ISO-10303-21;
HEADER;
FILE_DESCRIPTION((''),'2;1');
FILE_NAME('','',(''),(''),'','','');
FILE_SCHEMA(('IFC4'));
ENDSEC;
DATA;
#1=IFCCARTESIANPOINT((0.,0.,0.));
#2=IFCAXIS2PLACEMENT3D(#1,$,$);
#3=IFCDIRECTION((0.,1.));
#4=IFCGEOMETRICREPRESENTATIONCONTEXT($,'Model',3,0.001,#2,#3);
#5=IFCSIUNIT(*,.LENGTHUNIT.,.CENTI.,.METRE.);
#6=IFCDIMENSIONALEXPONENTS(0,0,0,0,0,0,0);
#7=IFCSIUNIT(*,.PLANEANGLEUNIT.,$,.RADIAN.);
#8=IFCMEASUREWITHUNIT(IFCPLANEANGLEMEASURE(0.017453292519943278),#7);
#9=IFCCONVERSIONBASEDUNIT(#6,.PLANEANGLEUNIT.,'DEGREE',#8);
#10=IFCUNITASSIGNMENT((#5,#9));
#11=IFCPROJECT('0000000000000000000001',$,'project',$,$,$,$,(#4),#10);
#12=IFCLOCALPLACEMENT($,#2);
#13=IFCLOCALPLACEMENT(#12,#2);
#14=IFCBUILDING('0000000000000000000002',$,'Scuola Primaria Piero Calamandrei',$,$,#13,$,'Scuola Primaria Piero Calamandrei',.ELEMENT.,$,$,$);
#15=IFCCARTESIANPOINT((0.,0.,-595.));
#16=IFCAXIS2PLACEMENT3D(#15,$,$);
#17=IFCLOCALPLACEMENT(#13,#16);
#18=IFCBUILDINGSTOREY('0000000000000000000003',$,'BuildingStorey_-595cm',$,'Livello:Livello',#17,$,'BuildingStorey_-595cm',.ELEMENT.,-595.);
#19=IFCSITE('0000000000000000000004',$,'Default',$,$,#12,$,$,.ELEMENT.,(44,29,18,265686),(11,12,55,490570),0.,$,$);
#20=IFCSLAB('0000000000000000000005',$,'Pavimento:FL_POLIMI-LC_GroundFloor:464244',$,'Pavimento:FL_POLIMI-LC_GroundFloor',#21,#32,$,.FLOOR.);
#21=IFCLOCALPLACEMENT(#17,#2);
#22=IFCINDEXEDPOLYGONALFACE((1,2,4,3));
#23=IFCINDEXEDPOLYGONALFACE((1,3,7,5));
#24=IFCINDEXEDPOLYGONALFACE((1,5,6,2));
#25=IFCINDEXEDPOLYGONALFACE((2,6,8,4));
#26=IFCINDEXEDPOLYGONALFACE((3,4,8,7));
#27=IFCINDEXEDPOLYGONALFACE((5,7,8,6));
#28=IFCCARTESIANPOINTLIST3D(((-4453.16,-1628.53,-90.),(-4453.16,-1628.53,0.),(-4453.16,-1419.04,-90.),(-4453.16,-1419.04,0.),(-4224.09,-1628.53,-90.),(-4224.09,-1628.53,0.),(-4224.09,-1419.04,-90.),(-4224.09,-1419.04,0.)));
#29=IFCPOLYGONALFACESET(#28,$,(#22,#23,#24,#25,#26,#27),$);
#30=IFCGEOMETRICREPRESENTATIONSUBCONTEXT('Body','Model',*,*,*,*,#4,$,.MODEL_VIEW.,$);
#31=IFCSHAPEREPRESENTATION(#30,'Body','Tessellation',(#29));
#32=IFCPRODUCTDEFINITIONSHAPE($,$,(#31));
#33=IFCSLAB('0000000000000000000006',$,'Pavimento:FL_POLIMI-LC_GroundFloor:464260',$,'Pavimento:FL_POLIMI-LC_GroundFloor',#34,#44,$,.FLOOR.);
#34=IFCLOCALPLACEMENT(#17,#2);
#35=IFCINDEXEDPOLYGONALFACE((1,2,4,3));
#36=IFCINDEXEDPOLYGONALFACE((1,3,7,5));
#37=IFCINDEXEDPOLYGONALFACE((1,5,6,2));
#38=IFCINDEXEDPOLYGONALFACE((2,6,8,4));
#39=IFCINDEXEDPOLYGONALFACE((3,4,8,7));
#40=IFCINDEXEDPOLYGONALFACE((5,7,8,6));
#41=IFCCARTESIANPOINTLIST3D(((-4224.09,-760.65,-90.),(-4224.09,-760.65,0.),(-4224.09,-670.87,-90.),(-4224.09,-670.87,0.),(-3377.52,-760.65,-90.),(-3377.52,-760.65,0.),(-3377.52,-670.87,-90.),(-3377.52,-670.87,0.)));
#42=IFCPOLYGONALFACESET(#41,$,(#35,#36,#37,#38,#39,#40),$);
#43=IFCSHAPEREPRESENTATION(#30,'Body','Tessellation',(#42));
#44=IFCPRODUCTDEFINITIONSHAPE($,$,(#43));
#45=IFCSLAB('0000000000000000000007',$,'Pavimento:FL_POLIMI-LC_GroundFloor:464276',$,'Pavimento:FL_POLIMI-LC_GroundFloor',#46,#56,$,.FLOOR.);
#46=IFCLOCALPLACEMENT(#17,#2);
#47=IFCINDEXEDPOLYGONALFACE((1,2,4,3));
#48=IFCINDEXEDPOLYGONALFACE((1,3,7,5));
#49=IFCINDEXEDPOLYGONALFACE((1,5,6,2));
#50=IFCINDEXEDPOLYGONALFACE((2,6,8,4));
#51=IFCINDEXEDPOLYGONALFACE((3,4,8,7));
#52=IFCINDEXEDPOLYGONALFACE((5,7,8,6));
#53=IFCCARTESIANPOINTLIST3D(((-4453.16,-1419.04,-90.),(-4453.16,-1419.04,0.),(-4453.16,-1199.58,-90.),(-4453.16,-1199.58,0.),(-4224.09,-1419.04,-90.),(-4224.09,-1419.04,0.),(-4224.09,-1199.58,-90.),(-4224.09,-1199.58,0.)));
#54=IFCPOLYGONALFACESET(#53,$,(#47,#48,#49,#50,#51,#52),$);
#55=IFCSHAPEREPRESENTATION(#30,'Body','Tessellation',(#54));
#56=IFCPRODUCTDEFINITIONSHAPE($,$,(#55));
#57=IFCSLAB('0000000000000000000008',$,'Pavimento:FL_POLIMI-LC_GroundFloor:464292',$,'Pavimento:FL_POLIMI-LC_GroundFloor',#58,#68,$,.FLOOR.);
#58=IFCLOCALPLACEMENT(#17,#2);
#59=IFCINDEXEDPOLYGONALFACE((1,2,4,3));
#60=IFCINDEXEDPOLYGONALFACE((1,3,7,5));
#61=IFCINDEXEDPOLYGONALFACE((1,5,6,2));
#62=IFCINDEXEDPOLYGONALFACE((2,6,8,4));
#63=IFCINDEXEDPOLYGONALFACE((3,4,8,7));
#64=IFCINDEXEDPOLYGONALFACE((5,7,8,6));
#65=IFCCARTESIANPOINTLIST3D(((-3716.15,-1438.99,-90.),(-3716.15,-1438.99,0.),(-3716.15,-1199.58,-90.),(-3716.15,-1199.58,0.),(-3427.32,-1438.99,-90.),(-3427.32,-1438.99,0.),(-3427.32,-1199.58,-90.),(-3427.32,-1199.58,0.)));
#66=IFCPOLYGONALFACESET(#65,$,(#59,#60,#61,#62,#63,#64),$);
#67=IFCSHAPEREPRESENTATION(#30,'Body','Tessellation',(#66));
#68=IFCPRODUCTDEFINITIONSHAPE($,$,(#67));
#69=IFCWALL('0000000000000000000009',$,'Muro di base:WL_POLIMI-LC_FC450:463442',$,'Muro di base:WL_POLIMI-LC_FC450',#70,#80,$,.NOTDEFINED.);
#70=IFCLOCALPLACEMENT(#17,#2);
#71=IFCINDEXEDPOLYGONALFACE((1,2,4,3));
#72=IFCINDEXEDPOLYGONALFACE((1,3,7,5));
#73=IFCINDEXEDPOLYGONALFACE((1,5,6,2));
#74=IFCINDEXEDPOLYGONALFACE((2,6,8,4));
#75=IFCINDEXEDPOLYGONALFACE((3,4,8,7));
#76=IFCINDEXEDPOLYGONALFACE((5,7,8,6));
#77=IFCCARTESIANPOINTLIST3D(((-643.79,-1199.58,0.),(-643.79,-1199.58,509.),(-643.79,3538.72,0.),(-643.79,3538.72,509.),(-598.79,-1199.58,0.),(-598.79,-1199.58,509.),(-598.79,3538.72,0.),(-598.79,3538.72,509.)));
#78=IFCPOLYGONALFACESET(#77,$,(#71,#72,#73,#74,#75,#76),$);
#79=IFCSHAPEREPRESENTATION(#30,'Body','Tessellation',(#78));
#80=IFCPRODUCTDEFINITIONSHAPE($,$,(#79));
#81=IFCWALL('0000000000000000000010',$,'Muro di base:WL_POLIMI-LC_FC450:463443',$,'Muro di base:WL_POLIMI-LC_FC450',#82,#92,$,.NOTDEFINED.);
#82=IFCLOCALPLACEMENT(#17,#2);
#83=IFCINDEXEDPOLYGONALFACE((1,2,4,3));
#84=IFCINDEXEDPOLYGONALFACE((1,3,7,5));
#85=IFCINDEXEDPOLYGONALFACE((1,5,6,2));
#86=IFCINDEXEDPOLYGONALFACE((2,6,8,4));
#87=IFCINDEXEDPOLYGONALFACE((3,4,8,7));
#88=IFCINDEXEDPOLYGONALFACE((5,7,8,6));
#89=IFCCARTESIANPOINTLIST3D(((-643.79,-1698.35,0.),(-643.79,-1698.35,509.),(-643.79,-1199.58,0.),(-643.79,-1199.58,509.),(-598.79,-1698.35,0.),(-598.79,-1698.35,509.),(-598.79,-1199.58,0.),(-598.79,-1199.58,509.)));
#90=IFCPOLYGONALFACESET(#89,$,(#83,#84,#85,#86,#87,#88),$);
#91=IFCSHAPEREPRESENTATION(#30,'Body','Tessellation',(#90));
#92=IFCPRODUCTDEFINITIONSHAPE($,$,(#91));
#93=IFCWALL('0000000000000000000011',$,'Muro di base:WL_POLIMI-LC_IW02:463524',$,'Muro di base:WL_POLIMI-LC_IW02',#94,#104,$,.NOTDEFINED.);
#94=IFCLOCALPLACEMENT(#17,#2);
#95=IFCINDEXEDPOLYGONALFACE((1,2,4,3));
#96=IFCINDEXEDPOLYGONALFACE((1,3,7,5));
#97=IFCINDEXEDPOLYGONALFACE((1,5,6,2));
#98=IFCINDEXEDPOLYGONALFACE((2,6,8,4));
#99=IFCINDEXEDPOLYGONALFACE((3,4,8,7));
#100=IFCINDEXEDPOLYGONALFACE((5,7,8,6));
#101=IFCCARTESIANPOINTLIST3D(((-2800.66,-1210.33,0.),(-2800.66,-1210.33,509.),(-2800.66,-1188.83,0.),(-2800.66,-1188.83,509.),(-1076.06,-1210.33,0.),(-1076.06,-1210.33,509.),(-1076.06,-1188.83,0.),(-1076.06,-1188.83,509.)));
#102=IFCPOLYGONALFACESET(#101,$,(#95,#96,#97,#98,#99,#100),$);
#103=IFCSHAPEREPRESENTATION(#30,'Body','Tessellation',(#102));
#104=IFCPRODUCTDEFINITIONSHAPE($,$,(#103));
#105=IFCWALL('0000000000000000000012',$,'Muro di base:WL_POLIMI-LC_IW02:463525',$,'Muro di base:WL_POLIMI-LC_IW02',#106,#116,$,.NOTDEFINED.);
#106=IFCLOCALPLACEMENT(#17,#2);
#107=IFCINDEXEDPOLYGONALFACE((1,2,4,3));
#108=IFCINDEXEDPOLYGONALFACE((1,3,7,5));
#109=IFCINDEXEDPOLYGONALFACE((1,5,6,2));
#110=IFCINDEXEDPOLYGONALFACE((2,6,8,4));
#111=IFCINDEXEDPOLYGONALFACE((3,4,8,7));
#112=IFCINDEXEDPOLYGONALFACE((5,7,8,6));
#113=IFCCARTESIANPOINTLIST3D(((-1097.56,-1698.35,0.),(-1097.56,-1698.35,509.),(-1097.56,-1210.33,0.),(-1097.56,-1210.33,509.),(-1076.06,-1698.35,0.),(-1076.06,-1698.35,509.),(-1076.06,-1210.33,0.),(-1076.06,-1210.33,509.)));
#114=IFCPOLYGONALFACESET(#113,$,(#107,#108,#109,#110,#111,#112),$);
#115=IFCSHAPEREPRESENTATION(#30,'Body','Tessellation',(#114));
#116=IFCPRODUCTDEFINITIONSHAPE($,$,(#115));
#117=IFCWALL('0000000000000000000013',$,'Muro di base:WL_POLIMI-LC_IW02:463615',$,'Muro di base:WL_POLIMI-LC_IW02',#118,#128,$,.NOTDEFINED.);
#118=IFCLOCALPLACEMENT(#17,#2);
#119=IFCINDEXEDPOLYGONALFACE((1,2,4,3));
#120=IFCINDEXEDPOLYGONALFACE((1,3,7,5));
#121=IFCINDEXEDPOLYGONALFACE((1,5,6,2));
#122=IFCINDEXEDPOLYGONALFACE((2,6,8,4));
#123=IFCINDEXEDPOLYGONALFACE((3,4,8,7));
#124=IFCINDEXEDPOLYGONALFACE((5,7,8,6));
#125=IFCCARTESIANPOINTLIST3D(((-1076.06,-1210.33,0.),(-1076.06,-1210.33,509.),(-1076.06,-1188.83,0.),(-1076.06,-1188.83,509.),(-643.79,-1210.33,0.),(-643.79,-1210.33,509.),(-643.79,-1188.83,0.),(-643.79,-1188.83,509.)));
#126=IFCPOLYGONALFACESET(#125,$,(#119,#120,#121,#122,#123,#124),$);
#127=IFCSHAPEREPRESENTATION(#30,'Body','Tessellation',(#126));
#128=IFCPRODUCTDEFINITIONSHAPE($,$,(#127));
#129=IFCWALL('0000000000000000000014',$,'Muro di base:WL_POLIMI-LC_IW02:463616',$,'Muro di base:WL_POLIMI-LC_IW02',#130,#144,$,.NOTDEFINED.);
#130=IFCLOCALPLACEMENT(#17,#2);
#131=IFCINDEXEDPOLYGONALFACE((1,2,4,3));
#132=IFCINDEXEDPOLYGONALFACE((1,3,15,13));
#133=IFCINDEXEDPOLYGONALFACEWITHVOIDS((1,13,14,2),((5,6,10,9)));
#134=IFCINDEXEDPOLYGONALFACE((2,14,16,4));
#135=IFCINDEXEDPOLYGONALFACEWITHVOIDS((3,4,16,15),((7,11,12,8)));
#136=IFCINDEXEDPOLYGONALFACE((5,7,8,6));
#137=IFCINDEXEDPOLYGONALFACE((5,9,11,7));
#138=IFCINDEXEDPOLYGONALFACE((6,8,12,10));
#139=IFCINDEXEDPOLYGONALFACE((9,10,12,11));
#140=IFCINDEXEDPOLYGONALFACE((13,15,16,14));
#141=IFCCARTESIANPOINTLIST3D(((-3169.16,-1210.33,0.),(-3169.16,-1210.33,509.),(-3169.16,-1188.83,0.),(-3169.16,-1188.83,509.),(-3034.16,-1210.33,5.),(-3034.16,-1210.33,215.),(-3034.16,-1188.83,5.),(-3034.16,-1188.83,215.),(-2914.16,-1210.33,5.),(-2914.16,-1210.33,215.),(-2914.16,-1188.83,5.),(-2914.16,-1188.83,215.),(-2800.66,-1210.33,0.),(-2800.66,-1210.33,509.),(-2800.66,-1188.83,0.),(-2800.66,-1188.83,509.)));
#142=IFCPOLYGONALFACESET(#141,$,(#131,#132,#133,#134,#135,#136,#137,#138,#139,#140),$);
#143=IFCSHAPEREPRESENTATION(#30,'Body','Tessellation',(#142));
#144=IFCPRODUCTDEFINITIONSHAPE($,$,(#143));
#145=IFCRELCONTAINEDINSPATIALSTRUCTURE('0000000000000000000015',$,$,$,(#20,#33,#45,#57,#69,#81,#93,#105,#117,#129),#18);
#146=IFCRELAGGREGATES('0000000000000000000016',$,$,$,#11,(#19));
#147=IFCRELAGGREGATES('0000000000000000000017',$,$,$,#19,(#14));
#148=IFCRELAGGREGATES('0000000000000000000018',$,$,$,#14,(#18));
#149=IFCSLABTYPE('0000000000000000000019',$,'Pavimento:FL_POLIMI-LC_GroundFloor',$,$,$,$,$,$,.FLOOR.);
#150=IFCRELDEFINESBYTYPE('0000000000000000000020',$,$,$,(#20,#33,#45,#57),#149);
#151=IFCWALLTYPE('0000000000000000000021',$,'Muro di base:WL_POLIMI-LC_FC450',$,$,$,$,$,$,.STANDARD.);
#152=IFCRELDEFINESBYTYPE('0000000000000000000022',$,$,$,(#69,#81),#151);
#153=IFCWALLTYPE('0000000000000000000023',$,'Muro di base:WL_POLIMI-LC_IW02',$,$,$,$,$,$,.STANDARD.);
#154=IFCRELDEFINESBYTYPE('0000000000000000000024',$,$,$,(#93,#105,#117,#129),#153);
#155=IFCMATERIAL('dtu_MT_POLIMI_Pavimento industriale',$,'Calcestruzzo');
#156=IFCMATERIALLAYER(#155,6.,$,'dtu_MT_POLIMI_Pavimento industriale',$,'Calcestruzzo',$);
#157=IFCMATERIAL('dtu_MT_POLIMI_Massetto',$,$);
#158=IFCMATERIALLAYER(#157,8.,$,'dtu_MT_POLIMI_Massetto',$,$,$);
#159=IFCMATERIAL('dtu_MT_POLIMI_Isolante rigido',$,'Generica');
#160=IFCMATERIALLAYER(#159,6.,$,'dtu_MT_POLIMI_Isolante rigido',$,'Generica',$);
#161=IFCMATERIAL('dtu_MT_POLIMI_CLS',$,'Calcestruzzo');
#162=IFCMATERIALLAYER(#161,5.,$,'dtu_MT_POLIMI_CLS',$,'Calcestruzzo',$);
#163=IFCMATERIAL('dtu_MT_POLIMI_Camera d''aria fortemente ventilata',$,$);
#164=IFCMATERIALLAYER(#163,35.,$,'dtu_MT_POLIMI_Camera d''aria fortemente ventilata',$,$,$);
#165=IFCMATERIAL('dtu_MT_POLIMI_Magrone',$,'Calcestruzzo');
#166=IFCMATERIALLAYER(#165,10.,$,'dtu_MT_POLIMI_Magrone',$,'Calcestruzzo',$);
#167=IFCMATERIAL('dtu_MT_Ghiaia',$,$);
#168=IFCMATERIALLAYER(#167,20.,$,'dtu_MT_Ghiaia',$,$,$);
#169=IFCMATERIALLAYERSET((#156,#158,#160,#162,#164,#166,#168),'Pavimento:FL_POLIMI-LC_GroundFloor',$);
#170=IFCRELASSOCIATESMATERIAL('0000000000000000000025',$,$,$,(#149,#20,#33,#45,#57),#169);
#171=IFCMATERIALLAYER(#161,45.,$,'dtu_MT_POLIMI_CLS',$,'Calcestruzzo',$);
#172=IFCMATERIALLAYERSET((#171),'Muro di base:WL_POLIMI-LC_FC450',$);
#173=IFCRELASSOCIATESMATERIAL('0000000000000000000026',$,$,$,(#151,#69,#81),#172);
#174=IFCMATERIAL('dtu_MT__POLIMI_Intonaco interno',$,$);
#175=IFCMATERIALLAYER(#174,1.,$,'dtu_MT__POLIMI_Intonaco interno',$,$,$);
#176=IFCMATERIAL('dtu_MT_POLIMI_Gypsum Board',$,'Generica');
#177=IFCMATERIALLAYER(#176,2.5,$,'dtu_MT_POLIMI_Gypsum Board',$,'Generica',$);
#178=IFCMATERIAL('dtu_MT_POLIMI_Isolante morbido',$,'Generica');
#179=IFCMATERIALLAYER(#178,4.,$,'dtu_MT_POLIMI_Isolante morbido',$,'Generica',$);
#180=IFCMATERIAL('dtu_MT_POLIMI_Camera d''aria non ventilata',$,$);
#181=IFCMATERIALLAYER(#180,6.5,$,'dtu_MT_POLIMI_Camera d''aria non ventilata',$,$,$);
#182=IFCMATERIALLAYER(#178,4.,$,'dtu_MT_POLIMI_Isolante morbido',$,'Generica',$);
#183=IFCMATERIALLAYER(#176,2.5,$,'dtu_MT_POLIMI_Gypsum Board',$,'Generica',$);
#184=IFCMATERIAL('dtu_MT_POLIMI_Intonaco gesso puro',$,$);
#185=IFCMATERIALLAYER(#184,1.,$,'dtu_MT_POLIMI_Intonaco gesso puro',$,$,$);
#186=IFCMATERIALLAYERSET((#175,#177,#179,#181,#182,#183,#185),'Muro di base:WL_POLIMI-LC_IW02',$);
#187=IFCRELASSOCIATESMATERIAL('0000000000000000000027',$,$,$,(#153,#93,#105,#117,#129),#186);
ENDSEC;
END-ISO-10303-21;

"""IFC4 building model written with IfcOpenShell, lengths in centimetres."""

from ifc_helpers import new_model, entity, si_unit, converted_unit, direction, frame, frame_2d, origin, origin_2d_with_axis, place, context, subcontext, project, spatial, polyline, rectangle, extrude, clip, bounded_halfspace, material, layer, layer_set, layer_usage, type_object, element, save


model = new_model("IFC4")

# Units and contexts
model_context = context("Model", 3, precision=0.001, world=origin(), true_north=direction((0.0, 1.0)))
body_context = subcontext(model_context, "Body", "Model", "MODEL_VIEW")
ifc_project = project(units=[si_unit("LENGTHUNIT", "METRE", prefix="CENTI"), converted_unit("PLANEANGLEUNIT", "DEGREE", entity("IfcPlaneAngleMeasure", 0.017453292519943278), si_unit("PLANEANGLEUNIT", "RADIAN"), dimensions=[0, 0, 0, 0, 0, 0, 0])], contexts=[model_context])

# Site, building, storey
site_placement = place(None, origin())
site = spatial("IfcSite", under=ifc_project, at=site_placement, Name="Default", CompositionType="ELEMENT", RefLatitude=(44, 29, 18, 265686), RefLongitude=(11, 12, 55, 490570), RefElevation=0.0)
building_placement = place(site_placement, origin())
building = spatial("IfcBuilding", under=site, at=building_placement, Name="Scuola Primaria Piero Calamandrei", LongName="Scuola Primaria Piero Calamandrei", CompositionType="ELEMENT")
storey_placement = place(building_placement, frame((0.0, 0.0, -595.0)))
storey = spatial("IfcBuildingStorey", under=building, at=storey_placement, Name="BuildingStorey_-595cm", ObjectType="Livello:Livello", LongName="BuildingStorey_-595cm", CompositionType="ELEMENT", Elevation=-595.0)

# Slabs
ifc_material_1 = material(Name="dtu_MT_POLIMI_Pavimento industriale", Category="Calcestruzzo")
ifc_layer_1 = layer(ifc_material_1, 6.0, Name="dtu_MT_POLIMI_Pavimento industriale", Category="Calcestruzzo")
ifc_material_2 = material(Name="dtu_MT_POLIMI_Massetto")
ifc_layer_2 = layer(ifc_material_2, 8.0, Name="dtu_MT_POLIMI_Massetto")
ifc_material_3 = material(Name="dtu_MT_POLIMI_Isolante rigido", Category="Generica")
ifc_layer_3 = layer(ifc_material_3, 6.0, Name="dtu_MT_POLIMI_Isolante rigido", Category="Generica")
ifc_material_4 = material(Name="dtu_MT_POLIMI_CLS", Category="Calcestruzzo")
ifc_layer_4 = layer(ifc_material_4, 5.0, Name="dtu_MT_POLIMI_CLS", Category="Calcestruzzo")
ifc_material_5 = material(Name="dtu_MT_POLIMI_Camera d'aria fortemente ventilata")
ifc_layer_5 = layer(ifc_material_5, 35.0, Name="dtu_MT_POLIMI_Camera d'aria fortemente ventilata")
ifc_material_6 = material(Name="dtu_MT_POLIMI_Magrone", Category="Calcestruzzo")
ifc_layer_6 = layer(ifc_material_6, 10.0, Name="dtu_MT_POLIMI_Magrone", Category="Calcestruzzo")
ifc_material_7 = material(Name="dtu_MT_Ghiaia")
ifc_layer_7 = layer(ifc_material_7, 20.0, Name="dtu_MT_Ghiaia")
ifc_layer_set_1 = layer_set([ifc_layer_1, ifc_layer_2, ifc_layer_3, ifc_layer_4, ifc_layer_5, ifc_layer_6, ifc_layer_7], Name="Pavimento:FL_POLIMI-LC_GroundFloor")
slab_type = type_object("IfcSlabType", Name="Pavimento:FL_POLIMI-LC_GroundFloor", PredefinedType="FLOOR", material=ifc_layer_set_1)
ifc_layer_usage_1 = layer_usage(ifc_layer_set_1, "AXIS3", "POSITIVE", 0.0)
slab_1_placement = place(storey_placement, origin())
element("IfcSlab", 1, at=slab_1_placement, inside=storey, type_object=slab_type, material=ifc_layer_usage_1, Name="Pavimento:FL_POLIMI-LC_GroundFloor:464244", ObjectType="Pavimento:FL_POLIMI-LC_GroundFloor", PredefinedType="FLOOR", context=body_context, shape_type="SweptSolid", body=[
    extrude(rectangle(XDim=209.49, YDim=229.07, at=frame_2d((0.0, 0.0), x_axis=(1.0, 0.0))), frame((-4338.63, -1523.78, 0.0), z_axis=(0.0, 0.0, -1.0), x_axis=(0.0, 1.0, 0.0)), (0.0, 0.0, 1.0), 90.0),
])
ifc_layer_usage_2 = layer_usage(ifc_layer_set_1, "AXIS3", "POSITIVE", 0.0)
slab_2_placement = place(storey_placement, origin())
element("IfcSlab", 2, at=slab_2_placement, inside=storey, type_object=slab_type, material=ifc_layer_usage_2, Name="Pavimento:FL_POLIMI-LC_GroundFloor:464260", ObjectType="Pavimento:FL_POLIMI-LC_GroundFloor", PredefinedType="FLOOR", context=body_context, shape_type="SweptSolid", body=[
    extrude(rectangle(XDim=89.78, YDim=846.57, at=frame_2d((0.0, 0.0), x_axis=(1.0, 0.0))), frame((-3800.81, -715.76, 0.0), z_axis=(0.0, 0.0, -1.0), x_axis=(0.0, 1.0, 0.0)), (0.0, 0.0, 1.0), 90.0),
])
ifc_layer_usage_3 = layer_usage(ifc_layer_set_1, "AXIS3", "POSITIVE", 0.0)
slab_3_placement = place(storey_placement, origin())
element("IfcSlab", 3, at=slab_3_placement, inside=storey, type_object=slab_type, material=ifc_layer_usage_3, Name="Pavimento:FL_POLIMI-LC_GroundFloor:464276", ObjectType="Pavimento:FL_POLIMI-LC_GroundFloor", PredefinedType="FLOOR", context=body_context, shape_type="SweptSolid", body=[
    extrude(rectangle(XDim=219.46, YDim=229.07, at=frame_2d((0.0, 0.0), x_axis=(1.0, 0.0))), frame((-4338.63, -1309.31, 0.0), z_axis=(0.0, 0.0, -1.0), x_axis=(0.0, 1.0, 0.0)), (0.0, 0.0, 1.0), 90.0),
])
ifc_layer_usage_4 = layer_usage(ifc_layer_set_1, "AXIS3", "POSITIVE", 0.0)
slab_4_placement = place(storey_placement, origin())
element("IfcSlab", 4, at=slab_4_placement, inside=storey, type_object=slab_type, material=ifc_layer_usage_4, Name="Pavimento:FL_POLIMI-LC_GroundFloor:464292", ObjectType="Pavimento:FL_POLIMI-LC_GroundFloor", PredefinedType="FLOOR", context=body_context, shape_type="SweptSolid", body=[
    extrude(rectangle(XDim=239.41, YDim=288.83, at=origin_2d_with_axis()), frame((-3571.74, -1319.28, 0.0), z_axis=(0.0, 0.0, -1.0), x_axis=(0.0, 1.0, 0.0)), (0.0, 0.0, 1.0), 90.0),
])

# Walls
ifc_layer_8 = layer(ifc_material_4, 45.0, Name="dtu_MT_POLIMI_CLS", Category="Calcestruzzo")
ifc_layer_set_2 = layer_set([ifc_layer_8], Name="Muro di base:WL_POLIMI-LC_FC450")
ifc_layer_usage_5 = layer_usage(ifc_layer_set_2, "AXIS2", "NEGATIVE", 22.5)
wall_type_1 = type_object("IfcWallType", Name="Muro di base:WL_POLIMI-LC_FC450", PredefinedType="STANDARD", material=ifc_layer_set_2)
wall_1_placement = place(storey_placement, frame((-621.29, 3538.72, 0.0), z_axis=(0.0, 0.0, 1.0), x_axis=(0.0, -1.0, 0.0)))
element("IfcWall", 5, at=wall_1_placement, inside=storey, type_object=wall_type_1, material=ifc_layer_usage_5, Name="Muro di base:WL_POLIMI-LC_FC450:463442", ObjectType="Muro di base:WL_POLIMI-LC_FC450", PredefinedType="NOTDEFINED", context=body_context, shape_type="Clipping", body=[
    clip(extrude(rectangle(XDim=4738.29, YDim=45.0, at=frame_2d((2369.15, 0.0), x_axis=(-1.0, 0.0))), origin(), (0.0, 0.0, 1.0), 509.0), bounded_halfspace(frame((0.0, -22.5, 509.0), z_axis=(0.0, 0.0, 1.0), x_axis=(0.0, 1.0, 0.0)), False, frame((0.0, -22.5, 509.0)), polyline([(0.0, 0.0), (4727.54, 0.0), (4738.29, 0.0), (4738.29, 45.0), (0.0, 45.0), (0.0, 0.0)]))),
])
ifc_layer_usage_6 = layer_usage(ifc_layer_set_2, "AXIS2", "NEGATIVE", 22.5)
wall_2_placement = place(storey_placement, frame((-621.29, -1199.58, 0.0), z_axis=(0.0, 0.0, 1.0), x_axis=(0.0, -1.0, 0.0)))
element("IfcWall", 6, at=wall_2_placement, inside=storey, type_object=wall_type_1, material=ifc_layer_usage_6, Name="Muro di base:WL_POLIMI-LC_FC450:463443", ObjectType="Muro di base:WL_POLIMI-LC_FC450", PredefinedType="NOTDEFINED", context=body_context, shape_type="Clipping", body=[
    clip(extrude(rectangle(XDim=498.78, YDim=45.0, at=frame_2d((249.39, 0.0), x_axis=(-1.0, 0.0))), origin(), (0.0, 0.0, 1.0), 509.0), bounded_halfspace(frame((0.0, -22.5, 509.0), z_axis=(0.0, 0.0, 1.0), x_axis=(0.0, 1.0, 0.0)), False, frame((0.0, -22.5, 509.0)), polyline([(0.0, 0.0), (10.75, 0.0), (488.03, 0.0), (498.78, 0.0), (498.78, 45.0), (0.0, 45.0), (0.0, 0.0)]))),
])
ifc_material_8 = material(Name="dtu_MT__POLIMI_Intonaco interno")
ifc_layer_9 = layer(ifc_material_8, 1.0, Name="dtu_MT__POLIMI_Intonaco interno")
ifc_material_9 = material(Name="dtu_MT_POLIMI_Gypsum Board", Category="Generica")
ifc_layer_10 = layer(ifc_material_9, 2.5, Name="dtu_MT_POLIMI_Gypsum Board", Category="Generica")
ifc_material_10 = material(Name="dtu_MT_POLIMI_Isolante morbido", Category="Generica")
ifc_layer_11 = layer(ifc_material_10, 4.0, Name="dtu_MT_POLIMI_Isolante morbido", Category="Generica")
ifc_material_11 = material(Name="dtu_MT_POLIMI_Camera d'aria non ventilata")
ifc_layer_12 = layer(ifc_material_11, 6.5, Name="dtu_MT_POLIMI_Camera d'aria non ventilata")
ifc_layer_13 = layer(ifc_material_10, 4.0, Name="dtu_MT_POLIMI_Isolante morbido", Category="Generica")
ifc_layer_14 = layer(ifc_material_9, 2.5, Name="dtu_MT_POLIMI_Gypsum Board", Category="Generica")
ifc_material_12 = material(Name="dtu_MT_POLIMI_Intonaco gesso puro")
ifc_layer_15 = layer(ifc_material_12, 1.0, Name="dtu_MT_POLIMI_Intonaco gesso puro")
ifc_layer_set_3 = layer_set([ifc_layer_9, ifc_layer_10, ifc_layer_11, ifc_layer_12, ifc_layer_13, ifc_layer_14, ifc_layer_15], Name="Muro di base:WL_POLIMI-LC_IW02")
ifc_layer_usage_7 = layer_usage(ifc_layer_set_3, "AXIS2", "NEGATIVE", 10.75)
wall_type_2 = type_object("IfcWallType", Name="Muro di base:WL_POLIMI-LC_IW02", PredefinedType="STANDARD", material=ifc_layer_set_3)
wall_3_placement = place(storey_placement, frame((-2800.66, -1199.58, 0.0)))
element("IfcWall", 7, at=wall_3_placement, inside=storey, type_object=wall_type_2, material=ifc_layer_usage_7, Name="Muro di base:WL_POLIMI-LC_IW02:463524", ObjectType="Muro di base:WL_POLIMI-LC_IW02", PredefinedType="NOTDEFINED", context=body_context, shape_type="SweptSolid", body=[
    extrude(rectangle(XDim=1724.59, YDim=21.5, at=frame_2d((862.3, 0.0), x_axis=(-1.0, 0.0))), origin(), (0.0, 0.0, 1.0), 509.0),
])
ifc_layer_usage_8 = layer_usage(ifc_layer_set_3, "AXIS2", "NEGATIVE", 10.75)
wall_4_placement = place(storey_placement, frame((-1086.81, -1210.33, 0.0), z_axis=(0.0, 0.0, 1.0), x_axis=(0.0, -1.0, 0.0)))
element("IfcWall", 8, at=wall_4_placement, inside=storey, type_object=wall_type_2, material=ifc_layer_usage_8, Name="Muro di base:WL_POLIMI-LC_IW02:463525", ObjectType="Muro di base:WL_POLIMI-LC_IW02", PredefinedType="NOTDEFINED", context=body_context, shape_type="SweptSolid", body=[
    extrude(rectangle(XDim=488.03, YDim=21.5, at=frame_2d((244.01, 0.0), x_axis=(-1.0, 0.0))), origin(), (0.0, 0.0, 1.0), 509.0),
])
ifc_layer_usage_9 = layer_usage(ifc_layer_set_3, "AXIS2", "NEGATIVE", 10.75)
wall_5_placement = place(storey_placement, frame((-643.79, -1199.58, 0.0), z_axis=(0.0, 0.0, 1.0), x_axis=(-1.0, 0.0, 0.0)))
element("IfcWall", 9, at=wall_5_placement, inside=storey, type_object=wall_type_2, material=ifc_layer_usage_9, Name="Muro di base:WL_POLIMI-LC_IW02:463615", ObjectType="Muro di base:WL_POLIMI-LC_IW02", PredefinedType="NOTDEFINED", context=body_context, shape_type="SweptSolid", body=[
    extrude(rectangle(XDim=432.27, YDim=21.5, at=frame_2d((216.14, 0.0), x_axis=(-1.0, 0.0))), origin(), (0.0, 0.0, 1.0), 509.0),
])

# Wall, opening
ifc_layer_usage_10 = layer_usage(ifc_layer_set_3, "AXIS2", "NEGATIVE", 10.75)
wall_6_placement = place(storey_placement, frame((-2800.66, -1199.58, 0.0), z_axis=(0.0, 0.0, 1.0), x_axis=(-1.0, 0.0, 0.0)))
wall_6 = element("IfcWall", 10, at=wall_6_placement, inside=storey, type_object=wall_type_2, material=ifc_layer_usage_10, Name="Muro di base:WL_POLIMI-LC_IW02:463616", ObjectType="Muro di base:WL_POLIMI-LC_IW02", PredefinedType="NOTDEFINED", context=body_context, shape_type="SweptSolid", body=[
    extrude(rectangle(XDim=368.51, YDim=21.5, at=frame_2d((184.25, 0.0), x_axis=(-1.0, 0.0))), origin(), (0.0, 0.0, 1.0), 509.0),
])
opening_placement = place(wall_6_placement, frame((113.5, -10.75, 5.0)))
element("IfcOpeningElement", 11, at=opening_placement, cuts=wall_6, PredefinedType="OPENING", context=body_context, shape_type="SweptSolid", body=[
    extrude(rectangle(XDim=210.0, YDim=120.0, at=frame_2d((105.0, 60.0), x_axis=(1.0, 0.0))), frame((0.0, 0.0, 0.0), z_axis=(0.0, 1.0, 0.0), x_axis=(0.0, 0.0, 1.0)), (0.0, 0.0, 1.0), 21.5),
])

save(model, "model.ifc")
